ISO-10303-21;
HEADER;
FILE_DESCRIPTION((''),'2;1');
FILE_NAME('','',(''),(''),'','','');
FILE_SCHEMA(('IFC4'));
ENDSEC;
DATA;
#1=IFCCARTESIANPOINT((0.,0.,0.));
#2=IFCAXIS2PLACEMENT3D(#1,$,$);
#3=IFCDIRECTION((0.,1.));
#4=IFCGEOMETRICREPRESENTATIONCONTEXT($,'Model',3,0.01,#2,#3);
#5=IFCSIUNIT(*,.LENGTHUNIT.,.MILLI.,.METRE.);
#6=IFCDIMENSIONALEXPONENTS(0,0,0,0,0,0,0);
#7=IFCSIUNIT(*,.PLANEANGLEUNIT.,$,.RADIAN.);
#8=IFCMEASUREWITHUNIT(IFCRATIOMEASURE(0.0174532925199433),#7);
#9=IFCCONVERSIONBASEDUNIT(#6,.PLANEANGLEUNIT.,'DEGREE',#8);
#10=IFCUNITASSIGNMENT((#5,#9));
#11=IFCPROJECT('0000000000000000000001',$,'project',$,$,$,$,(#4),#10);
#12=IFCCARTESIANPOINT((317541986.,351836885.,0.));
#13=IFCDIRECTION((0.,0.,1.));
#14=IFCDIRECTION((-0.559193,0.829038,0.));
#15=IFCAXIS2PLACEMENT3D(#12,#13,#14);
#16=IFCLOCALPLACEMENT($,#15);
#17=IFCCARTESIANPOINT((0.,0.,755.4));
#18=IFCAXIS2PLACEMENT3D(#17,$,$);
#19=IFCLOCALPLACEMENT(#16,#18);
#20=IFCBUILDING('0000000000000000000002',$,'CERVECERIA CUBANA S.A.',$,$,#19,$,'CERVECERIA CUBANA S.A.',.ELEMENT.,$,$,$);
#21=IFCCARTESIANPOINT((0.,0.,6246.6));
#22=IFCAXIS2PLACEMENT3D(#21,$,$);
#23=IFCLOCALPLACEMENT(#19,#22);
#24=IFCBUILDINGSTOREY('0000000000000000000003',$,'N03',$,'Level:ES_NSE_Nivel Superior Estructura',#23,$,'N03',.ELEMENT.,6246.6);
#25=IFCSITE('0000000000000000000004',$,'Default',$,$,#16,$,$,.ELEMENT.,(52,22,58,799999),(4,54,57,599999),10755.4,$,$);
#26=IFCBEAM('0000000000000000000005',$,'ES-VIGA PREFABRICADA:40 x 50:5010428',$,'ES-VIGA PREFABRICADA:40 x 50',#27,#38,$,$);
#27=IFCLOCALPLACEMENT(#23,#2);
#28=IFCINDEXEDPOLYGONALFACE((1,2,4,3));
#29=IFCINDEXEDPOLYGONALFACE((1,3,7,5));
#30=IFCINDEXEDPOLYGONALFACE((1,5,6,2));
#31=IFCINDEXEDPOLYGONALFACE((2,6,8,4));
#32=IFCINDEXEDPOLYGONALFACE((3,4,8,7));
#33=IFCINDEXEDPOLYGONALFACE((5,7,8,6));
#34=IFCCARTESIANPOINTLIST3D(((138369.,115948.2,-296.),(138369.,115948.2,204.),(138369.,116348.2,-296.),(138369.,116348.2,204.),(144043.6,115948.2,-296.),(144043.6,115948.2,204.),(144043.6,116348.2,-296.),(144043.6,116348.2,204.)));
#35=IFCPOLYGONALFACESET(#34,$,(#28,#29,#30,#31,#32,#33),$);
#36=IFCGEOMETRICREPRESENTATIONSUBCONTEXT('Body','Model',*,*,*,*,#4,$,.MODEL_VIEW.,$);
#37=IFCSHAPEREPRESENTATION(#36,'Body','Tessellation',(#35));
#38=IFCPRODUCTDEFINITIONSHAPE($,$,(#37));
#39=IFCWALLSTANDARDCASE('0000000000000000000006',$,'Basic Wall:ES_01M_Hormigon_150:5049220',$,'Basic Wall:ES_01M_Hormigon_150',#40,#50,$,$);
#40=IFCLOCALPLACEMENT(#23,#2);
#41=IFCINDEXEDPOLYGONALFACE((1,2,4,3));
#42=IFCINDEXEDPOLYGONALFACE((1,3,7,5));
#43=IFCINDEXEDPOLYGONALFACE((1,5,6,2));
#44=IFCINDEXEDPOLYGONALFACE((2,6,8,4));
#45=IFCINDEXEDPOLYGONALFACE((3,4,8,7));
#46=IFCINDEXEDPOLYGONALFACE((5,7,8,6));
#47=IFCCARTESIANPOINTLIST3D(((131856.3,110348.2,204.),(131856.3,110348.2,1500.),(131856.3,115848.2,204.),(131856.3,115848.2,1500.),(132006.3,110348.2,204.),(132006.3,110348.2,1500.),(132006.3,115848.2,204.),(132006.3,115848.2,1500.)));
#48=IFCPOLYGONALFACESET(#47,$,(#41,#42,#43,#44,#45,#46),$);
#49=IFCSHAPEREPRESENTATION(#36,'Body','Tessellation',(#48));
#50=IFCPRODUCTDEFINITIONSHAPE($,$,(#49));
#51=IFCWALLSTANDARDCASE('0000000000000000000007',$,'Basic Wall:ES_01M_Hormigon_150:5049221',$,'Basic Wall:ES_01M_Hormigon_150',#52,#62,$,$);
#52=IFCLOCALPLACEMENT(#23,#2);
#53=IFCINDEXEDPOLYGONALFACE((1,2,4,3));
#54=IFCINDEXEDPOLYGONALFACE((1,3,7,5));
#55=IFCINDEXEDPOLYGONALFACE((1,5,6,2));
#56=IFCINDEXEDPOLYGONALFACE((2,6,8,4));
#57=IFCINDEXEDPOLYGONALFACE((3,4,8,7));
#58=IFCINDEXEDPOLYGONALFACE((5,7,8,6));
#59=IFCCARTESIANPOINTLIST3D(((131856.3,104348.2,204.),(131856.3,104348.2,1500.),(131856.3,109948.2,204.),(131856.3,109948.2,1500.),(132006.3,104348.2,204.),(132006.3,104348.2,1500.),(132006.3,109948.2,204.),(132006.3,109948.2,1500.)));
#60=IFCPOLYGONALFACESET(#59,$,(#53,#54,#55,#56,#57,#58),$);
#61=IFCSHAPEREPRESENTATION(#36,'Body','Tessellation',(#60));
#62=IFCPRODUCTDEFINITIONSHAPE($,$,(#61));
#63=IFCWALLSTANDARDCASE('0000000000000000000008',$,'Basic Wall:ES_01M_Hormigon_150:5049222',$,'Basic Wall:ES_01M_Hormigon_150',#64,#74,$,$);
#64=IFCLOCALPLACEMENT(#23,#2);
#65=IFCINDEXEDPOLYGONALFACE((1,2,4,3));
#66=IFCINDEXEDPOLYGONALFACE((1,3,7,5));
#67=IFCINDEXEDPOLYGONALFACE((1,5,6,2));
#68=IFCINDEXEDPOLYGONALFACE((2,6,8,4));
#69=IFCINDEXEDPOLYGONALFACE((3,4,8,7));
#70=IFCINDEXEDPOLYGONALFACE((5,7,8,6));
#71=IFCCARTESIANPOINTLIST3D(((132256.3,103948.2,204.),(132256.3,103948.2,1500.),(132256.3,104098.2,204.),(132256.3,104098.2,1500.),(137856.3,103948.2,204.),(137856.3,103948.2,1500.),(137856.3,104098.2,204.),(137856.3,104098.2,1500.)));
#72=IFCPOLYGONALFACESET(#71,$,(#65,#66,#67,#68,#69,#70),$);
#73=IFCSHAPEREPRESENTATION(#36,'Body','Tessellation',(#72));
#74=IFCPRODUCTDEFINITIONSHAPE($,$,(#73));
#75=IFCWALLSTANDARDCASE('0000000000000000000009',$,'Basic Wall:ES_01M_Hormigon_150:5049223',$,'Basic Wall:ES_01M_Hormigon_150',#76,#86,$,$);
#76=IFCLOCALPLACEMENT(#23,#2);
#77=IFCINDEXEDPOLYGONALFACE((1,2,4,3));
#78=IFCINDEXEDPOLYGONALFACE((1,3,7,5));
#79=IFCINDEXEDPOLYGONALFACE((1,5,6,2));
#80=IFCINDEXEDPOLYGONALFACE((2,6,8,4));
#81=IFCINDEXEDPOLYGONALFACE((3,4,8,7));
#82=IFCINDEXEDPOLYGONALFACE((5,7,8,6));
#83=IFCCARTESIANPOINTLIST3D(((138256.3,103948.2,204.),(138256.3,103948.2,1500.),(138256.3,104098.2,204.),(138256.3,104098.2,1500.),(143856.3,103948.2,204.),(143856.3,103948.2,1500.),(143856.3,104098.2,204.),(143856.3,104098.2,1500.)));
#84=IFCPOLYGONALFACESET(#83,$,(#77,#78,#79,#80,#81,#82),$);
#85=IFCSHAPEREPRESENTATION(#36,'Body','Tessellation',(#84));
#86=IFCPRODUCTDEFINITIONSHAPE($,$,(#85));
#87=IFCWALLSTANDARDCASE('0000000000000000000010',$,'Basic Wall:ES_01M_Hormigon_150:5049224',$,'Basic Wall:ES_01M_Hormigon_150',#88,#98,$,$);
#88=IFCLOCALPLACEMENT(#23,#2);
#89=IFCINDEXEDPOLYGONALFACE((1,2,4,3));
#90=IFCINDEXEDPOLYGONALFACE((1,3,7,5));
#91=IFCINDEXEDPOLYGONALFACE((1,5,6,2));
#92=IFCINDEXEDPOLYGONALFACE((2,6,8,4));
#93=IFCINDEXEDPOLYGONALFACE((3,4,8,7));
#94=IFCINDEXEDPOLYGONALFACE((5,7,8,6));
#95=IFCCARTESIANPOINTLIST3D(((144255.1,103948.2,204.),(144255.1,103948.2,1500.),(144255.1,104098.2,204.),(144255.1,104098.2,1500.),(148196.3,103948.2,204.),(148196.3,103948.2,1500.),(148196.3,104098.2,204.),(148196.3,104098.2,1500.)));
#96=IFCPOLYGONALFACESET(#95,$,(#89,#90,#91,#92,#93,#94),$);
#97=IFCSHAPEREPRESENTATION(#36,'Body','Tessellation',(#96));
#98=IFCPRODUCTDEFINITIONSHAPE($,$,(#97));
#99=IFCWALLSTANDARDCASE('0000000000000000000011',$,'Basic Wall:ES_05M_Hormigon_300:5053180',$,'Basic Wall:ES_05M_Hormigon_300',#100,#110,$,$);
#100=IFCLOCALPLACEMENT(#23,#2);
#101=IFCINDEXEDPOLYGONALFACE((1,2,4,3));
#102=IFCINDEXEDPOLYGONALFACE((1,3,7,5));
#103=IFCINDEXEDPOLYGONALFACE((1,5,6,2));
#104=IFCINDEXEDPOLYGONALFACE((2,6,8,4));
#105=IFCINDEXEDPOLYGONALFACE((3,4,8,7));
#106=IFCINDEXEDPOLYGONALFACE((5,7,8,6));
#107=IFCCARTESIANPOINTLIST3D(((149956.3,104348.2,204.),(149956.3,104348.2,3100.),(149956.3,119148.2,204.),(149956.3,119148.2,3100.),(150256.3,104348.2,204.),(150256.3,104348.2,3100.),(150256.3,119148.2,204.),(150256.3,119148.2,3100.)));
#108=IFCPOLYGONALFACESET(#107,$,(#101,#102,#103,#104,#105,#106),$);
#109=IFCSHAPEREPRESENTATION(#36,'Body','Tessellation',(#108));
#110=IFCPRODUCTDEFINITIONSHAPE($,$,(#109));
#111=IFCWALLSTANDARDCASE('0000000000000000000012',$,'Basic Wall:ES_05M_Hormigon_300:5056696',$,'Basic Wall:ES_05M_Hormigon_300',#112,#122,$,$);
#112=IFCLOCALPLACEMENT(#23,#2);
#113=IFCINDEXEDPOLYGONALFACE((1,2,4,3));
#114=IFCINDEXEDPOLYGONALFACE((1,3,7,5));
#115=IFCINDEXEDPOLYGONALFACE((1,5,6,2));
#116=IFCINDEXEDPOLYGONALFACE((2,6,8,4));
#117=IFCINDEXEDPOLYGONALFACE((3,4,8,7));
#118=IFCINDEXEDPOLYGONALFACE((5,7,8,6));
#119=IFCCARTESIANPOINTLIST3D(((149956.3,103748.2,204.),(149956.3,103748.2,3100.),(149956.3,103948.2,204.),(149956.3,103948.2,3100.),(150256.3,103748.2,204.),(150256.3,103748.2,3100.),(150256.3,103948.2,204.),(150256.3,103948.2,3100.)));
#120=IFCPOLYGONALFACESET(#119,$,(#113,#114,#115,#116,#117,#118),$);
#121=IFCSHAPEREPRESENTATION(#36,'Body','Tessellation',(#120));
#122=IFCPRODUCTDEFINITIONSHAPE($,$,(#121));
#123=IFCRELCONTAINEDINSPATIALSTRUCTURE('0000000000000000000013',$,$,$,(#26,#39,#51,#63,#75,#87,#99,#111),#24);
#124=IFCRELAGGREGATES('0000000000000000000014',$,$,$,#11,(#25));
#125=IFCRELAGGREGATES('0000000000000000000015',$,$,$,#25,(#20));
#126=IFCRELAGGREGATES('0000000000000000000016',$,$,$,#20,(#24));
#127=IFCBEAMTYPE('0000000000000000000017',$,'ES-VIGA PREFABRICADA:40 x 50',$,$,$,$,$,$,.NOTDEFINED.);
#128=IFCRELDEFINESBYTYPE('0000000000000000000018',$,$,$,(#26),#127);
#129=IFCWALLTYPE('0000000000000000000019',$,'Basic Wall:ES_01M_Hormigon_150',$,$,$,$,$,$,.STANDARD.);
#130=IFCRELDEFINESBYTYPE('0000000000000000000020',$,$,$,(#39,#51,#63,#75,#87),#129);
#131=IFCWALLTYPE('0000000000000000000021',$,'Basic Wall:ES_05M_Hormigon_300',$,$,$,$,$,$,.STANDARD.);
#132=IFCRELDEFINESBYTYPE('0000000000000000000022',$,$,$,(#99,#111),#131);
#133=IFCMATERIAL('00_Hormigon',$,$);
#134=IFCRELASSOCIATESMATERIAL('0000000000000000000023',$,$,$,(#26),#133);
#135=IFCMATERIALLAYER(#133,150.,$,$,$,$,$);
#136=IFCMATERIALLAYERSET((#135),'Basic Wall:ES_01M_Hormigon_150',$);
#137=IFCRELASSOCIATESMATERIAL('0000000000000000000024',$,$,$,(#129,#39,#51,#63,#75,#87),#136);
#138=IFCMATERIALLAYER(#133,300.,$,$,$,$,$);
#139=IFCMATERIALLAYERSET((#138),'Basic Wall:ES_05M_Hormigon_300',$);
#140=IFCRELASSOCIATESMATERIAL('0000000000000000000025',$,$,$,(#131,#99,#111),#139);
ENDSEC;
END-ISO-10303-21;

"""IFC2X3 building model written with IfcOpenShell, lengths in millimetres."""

from ifc_helpers import new_model, entity, si_unit, converted_unit, direction, frame, frame_2d, origin, place, context, subcontext, project, spatial, rectangle, extrude, material, layer, layer_set, layer_usage, type_object, element, save


model = new_model("IFC2X3")

# Units and contexts
model_context = context("Model", 3, precision=0.01, world=origin(), true_north=direction((0.0, 1.0)))
body_context = subcontext(model_context, "Body", "Model", "MODEL_VIEW")
ifc_project = project(units=[si_unit("LENGTHUNIT", "METRE", prefix="MILLI"), converted_unit("PLANEANGLEUNIT", "DEGREE", entity("IfcRatioMeasure", 0.0174532925199433), si_unit("PLANEANGLEUNIT", "RADIAN"), dimensions=[0, 0, 0, 0, 0, 0, 0])], contexts=[model_context])

# Site, building, storey
site_placement = place(None, frame((317541986.0, 351836885.0, 0.0), z_axis=(0.0, 0.0, 1.0), x_axis=(-0.559193, 0.829038, 0.0)))
site = spatial("IfcSite", under=ifc_project, at=site_placement, Name="Default", CompositionType="ELEMENT", RefLatitude=(52, 22, 58, 799999), RefLongitude=(4, 54, 57, 599999), RefElevation=10755.4)
building_placement = place(site_placement, frame((0.0, 0.0, 755.4)))
building = spatial("IfcBuilding", under=site, at=building_placement, Name="CERVECERIA CUBANA S.A.", LongName="CERVECERIA CUBANA S.A.", CompositionType="ELEMENT")
storey_placement = place(building_placement, frame((0.0, 0.0, 6246.6)))
storey = spatial("IfcBuildingStorey", under=building, at=storey_placement, Name="N03", ObjectType="Level:ES_NSE_Nivel Superior Estructura", LongName="N03", CompositionType="ELEMENT", Elevation=6246.6)

# Beam
ifc_material = material(Name="00_Hormigon")
beam_type = type_object("IfcBeamType", Name="ES-VIGA PREFABRICADA:40 x 50", PredefinedType="NOTDEFINED")
beam_placement = place(storey_placement, frame((138056.3, 116148.2, 204.0)))
element("IfcBeam", 1, at=beam_placement, inside=storey, type_object=beam_type, material=ifc_material, Name="ES-VIGA PREFABRICADA:40 x 50:5010428", ObjectType="ES-VIGA PREFABRICADA:40 x 50", context=body_context, shape_type="SweptSolid", body=[
    extrude(rectangle(XDim=500.0, YDim=400.0, at=frame_2d((0.0, 0.0), x_axis=(1.0, 0.0))), frame((312.7, 0.0, -250.0), z_axis=(1.0, 0.0, 0.0), x_axis=(0.0, 0.0, -1.0)), (0.0, 0.0, 1.0), 5674.6),
])

# Walls
ifc_layer_1 = layer(ifc_material, 150.0)
ifc_layer_set_1 = layer_set([ifc_layer_1], Name="Basic Wall:ES_01M_Hormigon_150")
ifc_layer_usage_1 = layer_usage(ifc_layer_set_1, "AXIS2", "NEGATIVE", 75.0)
wall_type_1 = type_object("IfcWallType", Name="Basic Wall:ES_01M_Hormigon_150", PredefinedType="STANDARD", material=ifc_layer_set_1)
wall_1_placement = place(storey_placement, frame((131931.3, 110348.2, 204.0), z_axis=(0.0, 0.0, 1.0), x_axis=(0.0, 1.0, 0.0)))
element("IfcWallStandardCase", 2, at=wall_1_placement, inside=storey, type_object=wall_type_1, material=ifc_layer_usage_1, Name="Basic Wall:ES_01M_Hormigon_150:5049220", ObjectType="Basic Wall:ES_01M_Hormigon_150", context=body_context, shape_type="SweptSolid", body=[
    extrude(rectangle(XDim=5500.0, YDim=150.0, at=frame_2d((2750.0, 0.0), x_axis=(-1.0, 0.0))), origin(), (0.0, 0.0, 1.0), 1296.0),
])
ifc_layer_usage_2 = layer_usage(ifc_layer_set_1, "AXIS2", "NEGATIVE", 75.0)
wall_2_placement = place(storey_placement, frame((131931.3, 104348.2, 204.0), z_axis=(0.0, 0.0, 1.0), x_axis=(0.0, 1.0, 0.0)))
element("IfcWallStandardCase", 3, at=wall_2_placement, inside=storey, type_object=wall_type_1, material=ifc_layer_usage_2, Name="Basic Wall:ES_01M_Hormigon_150:5049221", ObjectType="Basic Wall:ES_01M_Hormigon_150", context=body_context, shape_type="SweptSolid", body=[
    extrude(rectangle(XDim=5600.0, YDim=150.0, at=frame_2d((2800.0, 0.0), x_axis=(-1.0, 0.0))), origin(), (0.0, 0.0, 1.0), 1296.0),
])
ifc_layer_usage_3 = layer_usage(ifc_layer_set_1, "AXIS2", "NEGATIVE", 75.0)
wall_3_placement = place(storey_placement, frame((132256.3, 104023.2, 204.0)))
element("IfcWallStandardCase", 4, at=wall_3_placement, inside=storey, type_object=wall_type_1, material=ifc_layer_usage_3, Name="Basic Wall:ES_01M_Hormigon_150:5049222", ObjectType="Basic Wall:ES_01M_Hormigon_150", context=body_context, shape_type="SweptSolid", body=[
    extrude(rectangle(XDim=5600.0, YDim=150.0, at=frame_2d((2800.0, 0.0), x_axis=(-1.0, 0.0))), origin(), (0.0, 0.0, 1.0), 1296.0),
])
ifc_layer_usage_4 = layer_usage(ifc_layer_set_1, "AXIS2", "NEGATIVE", 75.0)
wall_4_placement = place(storey_placement, frame((138256.3, 104023.2, 204.0)))
element("IfcWallStandardCase", 5, at=wall_4_placement, inside=storey, type_object=wall_type_1, material=ifc_layer_usage_4, Name="Basic Wall:ES_01M_Hormigon_150:5049223", ObjectType="Basic Wall:ES_01M_Hormigon_150", context=body_context, shape_type="SweptSolid", body=[
    extrude(rectangle(XDim=5600.0, YDim=150.0, at=frame_2d((2800.0, 0.0), x_axis=(-1.0, 0.0))), origin(), (0.0, 0.0, 1.0), 1296.0),
])
ifc_layer_usage_5 = layer_usage(ifc_layer_set_1, "AXIS2", "NEGATIVE", 75.0)
wall_5_placement = place(storey_placement, frame((144255.1, 104023.2, 204.0)))
element("IfcWallStandardCase", 6, at=wall_5_placement, inside=storey, type_object=wall_type_1, material=ifc_layer_usage_5, Name="Basic Wall:ES_01M_Hormigon_150:5049224", ObjectType="Basic Wall:ES_01M_Hormigon_150", context=body_context, shape_type="SweptSolid", body=[
    extrude(rectangle(XDim=3941.2, YDim=150.0, at=frame_2d((1970.6, 0.0), x_axis=(-1.0, 0.0))), origin(), (0.0, 0.0, 1.0), 1296.0),
])
ifc_layer_2 = layer(ifc_material, 300.0)
ifc_layer_set_2 = layer_set([ifc_layer_2], Name="Basic Wall:ES_05M_Hormigon_300")
ifc_layer_usage_6 = layer_usage(ifc_layer_set_2, "AXIS2", "NEGATIVE", 150.0)
wall_type_2 = type_object("IfcWallType", Name="Basic Wall:ES_05M_Hormigon_300", PredefinedType="STANDARD", material=ifc_layer_set_2)
wall_6_placement = place(storey_placement, frame((150106.3, 119148.2, 204.0), z_axis=(0.0, 0.0, 1.0), x_axis=(0.0, -1.0, 0.0)))
element("IfcWallStandardCase", 7, at=wall_6_placement, inside=storey, type_object=wall_type_2, material=ifc_layer_usage_6, Name="Basic Wall:ES_05M_Hormigon_300:5053180", ObjectType="Basic Wall:ES_05M_Hormigon_300", context=body_context, shape_type="SweptSolid", body=[
    extrude(rectangle(XDim=14800.0, YDim=300.0, at=frame_2d((7400.0, 0.0), x_axis=(-1.0, 0.0))), origin(), (0.0, 0.0, 1.0), 2896.0),
])
ifc_layer_usage_7 = layer_usage(ifc_layer_set_2, "AXIS2", "NEGATIVE", 150.0)
wall_7_placement = place(storey_placement, frame((150106.3, 103948.2, 204.0), z_axis=(0.0, 0.0, 1.0), x_axis=(0.0, -1.0, 0.0)))
element("IfcWallStandardCase", 8, at=wall_7_placement, inside=storey, type_object=wall_type_2, material=ifc_layer_usage_7, Name="Basic Wall:ES_05M_Hormigon_300:5056696", ObjectType="Basic Wall:ES_05M_Hormigon_300", context=body_context, shape_type="SweptSolid", body=[
    extrude(rectangle(XDim=200.0, YDim=300.0, at=frame_2d((100.0, 0.0), x_axis=(-1.0, 0.0))), origin(), (0.0, 0.0, 1.0), 2896.0),
])

save(model, "model.ifc")
